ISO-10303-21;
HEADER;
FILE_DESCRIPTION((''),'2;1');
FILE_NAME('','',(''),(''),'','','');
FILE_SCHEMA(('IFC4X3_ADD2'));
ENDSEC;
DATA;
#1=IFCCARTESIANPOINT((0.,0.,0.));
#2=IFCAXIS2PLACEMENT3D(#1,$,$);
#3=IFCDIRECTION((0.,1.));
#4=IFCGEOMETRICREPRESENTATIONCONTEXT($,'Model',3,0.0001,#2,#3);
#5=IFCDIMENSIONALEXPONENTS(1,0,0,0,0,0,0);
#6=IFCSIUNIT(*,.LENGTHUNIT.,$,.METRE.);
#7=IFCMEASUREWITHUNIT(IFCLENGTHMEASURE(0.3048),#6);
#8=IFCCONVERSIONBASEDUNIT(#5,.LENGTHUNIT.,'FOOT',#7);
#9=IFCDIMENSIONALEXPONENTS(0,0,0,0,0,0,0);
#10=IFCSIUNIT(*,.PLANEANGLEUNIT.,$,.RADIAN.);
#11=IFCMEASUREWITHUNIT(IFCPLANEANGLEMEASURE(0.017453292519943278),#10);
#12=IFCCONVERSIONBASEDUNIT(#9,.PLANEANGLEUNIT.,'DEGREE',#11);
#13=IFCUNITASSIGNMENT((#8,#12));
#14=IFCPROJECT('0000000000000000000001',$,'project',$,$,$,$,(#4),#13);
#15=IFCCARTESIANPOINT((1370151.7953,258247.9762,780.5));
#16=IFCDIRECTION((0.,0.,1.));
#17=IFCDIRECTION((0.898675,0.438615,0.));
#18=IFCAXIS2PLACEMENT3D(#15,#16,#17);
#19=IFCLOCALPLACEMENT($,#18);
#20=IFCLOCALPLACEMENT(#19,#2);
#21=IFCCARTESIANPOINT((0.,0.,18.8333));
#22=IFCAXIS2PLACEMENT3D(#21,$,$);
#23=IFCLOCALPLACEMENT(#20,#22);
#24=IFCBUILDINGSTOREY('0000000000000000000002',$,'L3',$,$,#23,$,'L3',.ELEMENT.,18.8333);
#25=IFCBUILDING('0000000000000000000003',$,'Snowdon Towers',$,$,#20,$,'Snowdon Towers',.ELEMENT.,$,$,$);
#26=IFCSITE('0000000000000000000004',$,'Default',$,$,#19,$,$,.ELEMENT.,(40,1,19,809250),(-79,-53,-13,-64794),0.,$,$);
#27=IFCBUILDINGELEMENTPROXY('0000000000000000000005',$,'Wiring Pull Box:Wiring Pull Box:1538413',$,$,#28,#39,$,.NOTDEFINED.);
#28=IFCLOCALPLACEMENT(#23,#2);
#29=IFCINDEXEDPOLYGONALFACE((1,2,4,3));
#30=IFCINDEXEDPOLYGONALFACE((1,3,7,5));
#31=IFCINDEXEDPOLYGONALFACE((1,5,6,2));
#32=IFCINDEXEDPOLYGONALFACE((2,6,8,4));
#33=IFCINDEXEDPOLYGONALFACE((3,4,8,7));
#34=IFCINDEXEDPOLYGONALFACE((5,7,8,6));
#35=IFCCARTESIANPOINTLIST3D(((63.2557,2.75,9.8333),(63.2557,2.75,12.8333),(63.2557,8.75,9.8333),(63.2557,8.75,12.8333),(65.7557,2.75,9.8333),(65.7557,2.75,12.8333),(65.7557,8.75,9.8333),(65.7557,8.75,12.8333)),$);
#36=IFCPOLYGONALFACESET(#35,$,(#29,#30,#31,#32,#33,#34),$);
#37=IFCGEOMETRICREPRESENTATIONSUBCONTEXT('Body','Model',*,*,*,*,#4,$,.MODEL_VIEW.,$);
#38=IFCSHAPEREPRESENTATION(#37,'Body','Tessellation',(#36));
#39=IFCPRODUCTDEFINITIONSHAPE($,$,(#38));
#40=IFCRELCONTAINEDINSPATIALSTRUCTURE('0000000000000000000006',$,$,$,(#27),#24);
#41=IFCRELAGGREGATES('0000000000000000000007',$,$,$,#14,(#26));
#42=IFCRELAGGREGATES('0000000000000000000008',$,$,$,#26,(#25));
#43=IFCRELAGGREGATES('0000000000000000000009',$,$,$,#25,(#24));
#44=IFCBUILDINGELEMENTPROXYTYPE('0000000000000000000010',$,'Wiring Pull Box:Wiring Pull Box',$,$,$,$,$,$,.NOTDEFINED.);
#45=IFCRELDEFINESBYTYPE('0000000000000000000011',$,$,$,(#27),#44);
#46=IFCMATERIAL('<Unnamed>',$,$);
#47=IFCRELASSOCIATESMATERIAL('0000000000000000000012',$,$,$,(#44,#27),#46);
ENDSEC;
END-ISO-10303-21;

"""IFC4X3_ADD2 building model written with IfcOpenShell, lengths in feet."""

from ifc_helpers import new_model, entity, si_unit, converted_unit, direction, frame, frame_2d, origin, place, context, subcontext, project, spatial, rectangle, extrude, source, transform, mapped, material, type_object, type_shapes, element, save


model = new_model("IFC4X3_ADD2")

# Units and contexts
model_context = context("Model", 3, precision=0.0001, world=origin(), true_north=direction((0.0, 1.0)))
body_context = subcontext(model_context, "Body", "Model", "MODEL_VIEW")
ifc_project = project(units=[converted_unit("LENGTHUNIT", "FOOT", entity("IfcLengthMeasure", 0.3048), si_unit("LENGTHUNIT", "METRE"), dimensions=[1, 0, 0, 0, 0, 0, 0]), converted_unit("PLANEANGLEUNIT", "DEGREE", entity("IfcPlaneAngleMeasure", 0.017453292519943278), si_unit("PLANEANGLEUNIT", "RADIAN"), dimensions=[0, 0, 0, 0, 0, 0, 0])], contexts=[model_context])

# Site, building, storey
site_placement = place(None, frame((1370151.7953, 258247.9762, 780.5), z_axis=(0.0, 0.0, 1.0), x_axis=(0.898675, 0.438615, 0.0)))
site = spatial("IfcSite", under=ifc_project, at=site_placement, Name="Default", CompositionType="ELEMENT", RefLatitude=(40, 1, 19, 809250), RefLongitude=(-79, -53, -13, -64794), RefElevation=0.0)
building_placement = place(site_placement, origin())
building = spatial("IfcBuilding", under=site, at=building_placement, Name="Snowdon Towers", LongName="Snowdon Towers", CompositionType="ELEMENT")
storey_placement = place(building_placement, frame((0.0, 0.0, 18.8333)))
storey = spatial("IfcBuildingStorey", under=building, at=storey_placement, Name="L3", LongName="L3", CompositionType="ELEMENT", Elevation=18.8333)

# Building element proxy
ifc_material = material(Name="<Unnamed>")
building_element_proxy_type_1 = type_object("IfcBuildingElementProxyType", Name="Wiring Pull Box:Wiring Pull Box", PredefinedType="NOTDEFINED", material=ifc_material)
shared_shape_1 = source(origin(), body_context, "Body", "SweptSolid", [
    extrude(rectangle(XDim=6.0, YDim=2.5, at=frame_2d((0.0, 0.0), x_axis=(1.0, 0.0))), frame((0.0, 0.0, 0.0), z_axis=(0.0, 0.0, 1.0), x_axis=(-1.0, 0.0, 0.0)), (0.0, 0.0, 1.0), 3.0),
])
type_shapes(building_element_proxy_type_1, [shared_shape_1])
proxy_1_placement = place(storey_placement, frame((64.5057, 5.75, 9.8333), z_axis=(0.0, 0.0, 1.0), x_axis=(0.0, 1.0, 0.0)))
element("IfcBuildingElementProxy", 1, at=proxy_1_placement, inside=storey, type_object=building_element_proxy_type_1, material=ifc_material, Name="Wiring Pull Box:Wiring Pull Box:1538413", PredefinedType="NOTDEFINED", context=body_context, shape_type="MappedRepresentation", body=[
    mapped(shared_shape_1, transform((0.0, 0.0, 0.0), scale=1.0)),
])

save(model, "model.ifc")
